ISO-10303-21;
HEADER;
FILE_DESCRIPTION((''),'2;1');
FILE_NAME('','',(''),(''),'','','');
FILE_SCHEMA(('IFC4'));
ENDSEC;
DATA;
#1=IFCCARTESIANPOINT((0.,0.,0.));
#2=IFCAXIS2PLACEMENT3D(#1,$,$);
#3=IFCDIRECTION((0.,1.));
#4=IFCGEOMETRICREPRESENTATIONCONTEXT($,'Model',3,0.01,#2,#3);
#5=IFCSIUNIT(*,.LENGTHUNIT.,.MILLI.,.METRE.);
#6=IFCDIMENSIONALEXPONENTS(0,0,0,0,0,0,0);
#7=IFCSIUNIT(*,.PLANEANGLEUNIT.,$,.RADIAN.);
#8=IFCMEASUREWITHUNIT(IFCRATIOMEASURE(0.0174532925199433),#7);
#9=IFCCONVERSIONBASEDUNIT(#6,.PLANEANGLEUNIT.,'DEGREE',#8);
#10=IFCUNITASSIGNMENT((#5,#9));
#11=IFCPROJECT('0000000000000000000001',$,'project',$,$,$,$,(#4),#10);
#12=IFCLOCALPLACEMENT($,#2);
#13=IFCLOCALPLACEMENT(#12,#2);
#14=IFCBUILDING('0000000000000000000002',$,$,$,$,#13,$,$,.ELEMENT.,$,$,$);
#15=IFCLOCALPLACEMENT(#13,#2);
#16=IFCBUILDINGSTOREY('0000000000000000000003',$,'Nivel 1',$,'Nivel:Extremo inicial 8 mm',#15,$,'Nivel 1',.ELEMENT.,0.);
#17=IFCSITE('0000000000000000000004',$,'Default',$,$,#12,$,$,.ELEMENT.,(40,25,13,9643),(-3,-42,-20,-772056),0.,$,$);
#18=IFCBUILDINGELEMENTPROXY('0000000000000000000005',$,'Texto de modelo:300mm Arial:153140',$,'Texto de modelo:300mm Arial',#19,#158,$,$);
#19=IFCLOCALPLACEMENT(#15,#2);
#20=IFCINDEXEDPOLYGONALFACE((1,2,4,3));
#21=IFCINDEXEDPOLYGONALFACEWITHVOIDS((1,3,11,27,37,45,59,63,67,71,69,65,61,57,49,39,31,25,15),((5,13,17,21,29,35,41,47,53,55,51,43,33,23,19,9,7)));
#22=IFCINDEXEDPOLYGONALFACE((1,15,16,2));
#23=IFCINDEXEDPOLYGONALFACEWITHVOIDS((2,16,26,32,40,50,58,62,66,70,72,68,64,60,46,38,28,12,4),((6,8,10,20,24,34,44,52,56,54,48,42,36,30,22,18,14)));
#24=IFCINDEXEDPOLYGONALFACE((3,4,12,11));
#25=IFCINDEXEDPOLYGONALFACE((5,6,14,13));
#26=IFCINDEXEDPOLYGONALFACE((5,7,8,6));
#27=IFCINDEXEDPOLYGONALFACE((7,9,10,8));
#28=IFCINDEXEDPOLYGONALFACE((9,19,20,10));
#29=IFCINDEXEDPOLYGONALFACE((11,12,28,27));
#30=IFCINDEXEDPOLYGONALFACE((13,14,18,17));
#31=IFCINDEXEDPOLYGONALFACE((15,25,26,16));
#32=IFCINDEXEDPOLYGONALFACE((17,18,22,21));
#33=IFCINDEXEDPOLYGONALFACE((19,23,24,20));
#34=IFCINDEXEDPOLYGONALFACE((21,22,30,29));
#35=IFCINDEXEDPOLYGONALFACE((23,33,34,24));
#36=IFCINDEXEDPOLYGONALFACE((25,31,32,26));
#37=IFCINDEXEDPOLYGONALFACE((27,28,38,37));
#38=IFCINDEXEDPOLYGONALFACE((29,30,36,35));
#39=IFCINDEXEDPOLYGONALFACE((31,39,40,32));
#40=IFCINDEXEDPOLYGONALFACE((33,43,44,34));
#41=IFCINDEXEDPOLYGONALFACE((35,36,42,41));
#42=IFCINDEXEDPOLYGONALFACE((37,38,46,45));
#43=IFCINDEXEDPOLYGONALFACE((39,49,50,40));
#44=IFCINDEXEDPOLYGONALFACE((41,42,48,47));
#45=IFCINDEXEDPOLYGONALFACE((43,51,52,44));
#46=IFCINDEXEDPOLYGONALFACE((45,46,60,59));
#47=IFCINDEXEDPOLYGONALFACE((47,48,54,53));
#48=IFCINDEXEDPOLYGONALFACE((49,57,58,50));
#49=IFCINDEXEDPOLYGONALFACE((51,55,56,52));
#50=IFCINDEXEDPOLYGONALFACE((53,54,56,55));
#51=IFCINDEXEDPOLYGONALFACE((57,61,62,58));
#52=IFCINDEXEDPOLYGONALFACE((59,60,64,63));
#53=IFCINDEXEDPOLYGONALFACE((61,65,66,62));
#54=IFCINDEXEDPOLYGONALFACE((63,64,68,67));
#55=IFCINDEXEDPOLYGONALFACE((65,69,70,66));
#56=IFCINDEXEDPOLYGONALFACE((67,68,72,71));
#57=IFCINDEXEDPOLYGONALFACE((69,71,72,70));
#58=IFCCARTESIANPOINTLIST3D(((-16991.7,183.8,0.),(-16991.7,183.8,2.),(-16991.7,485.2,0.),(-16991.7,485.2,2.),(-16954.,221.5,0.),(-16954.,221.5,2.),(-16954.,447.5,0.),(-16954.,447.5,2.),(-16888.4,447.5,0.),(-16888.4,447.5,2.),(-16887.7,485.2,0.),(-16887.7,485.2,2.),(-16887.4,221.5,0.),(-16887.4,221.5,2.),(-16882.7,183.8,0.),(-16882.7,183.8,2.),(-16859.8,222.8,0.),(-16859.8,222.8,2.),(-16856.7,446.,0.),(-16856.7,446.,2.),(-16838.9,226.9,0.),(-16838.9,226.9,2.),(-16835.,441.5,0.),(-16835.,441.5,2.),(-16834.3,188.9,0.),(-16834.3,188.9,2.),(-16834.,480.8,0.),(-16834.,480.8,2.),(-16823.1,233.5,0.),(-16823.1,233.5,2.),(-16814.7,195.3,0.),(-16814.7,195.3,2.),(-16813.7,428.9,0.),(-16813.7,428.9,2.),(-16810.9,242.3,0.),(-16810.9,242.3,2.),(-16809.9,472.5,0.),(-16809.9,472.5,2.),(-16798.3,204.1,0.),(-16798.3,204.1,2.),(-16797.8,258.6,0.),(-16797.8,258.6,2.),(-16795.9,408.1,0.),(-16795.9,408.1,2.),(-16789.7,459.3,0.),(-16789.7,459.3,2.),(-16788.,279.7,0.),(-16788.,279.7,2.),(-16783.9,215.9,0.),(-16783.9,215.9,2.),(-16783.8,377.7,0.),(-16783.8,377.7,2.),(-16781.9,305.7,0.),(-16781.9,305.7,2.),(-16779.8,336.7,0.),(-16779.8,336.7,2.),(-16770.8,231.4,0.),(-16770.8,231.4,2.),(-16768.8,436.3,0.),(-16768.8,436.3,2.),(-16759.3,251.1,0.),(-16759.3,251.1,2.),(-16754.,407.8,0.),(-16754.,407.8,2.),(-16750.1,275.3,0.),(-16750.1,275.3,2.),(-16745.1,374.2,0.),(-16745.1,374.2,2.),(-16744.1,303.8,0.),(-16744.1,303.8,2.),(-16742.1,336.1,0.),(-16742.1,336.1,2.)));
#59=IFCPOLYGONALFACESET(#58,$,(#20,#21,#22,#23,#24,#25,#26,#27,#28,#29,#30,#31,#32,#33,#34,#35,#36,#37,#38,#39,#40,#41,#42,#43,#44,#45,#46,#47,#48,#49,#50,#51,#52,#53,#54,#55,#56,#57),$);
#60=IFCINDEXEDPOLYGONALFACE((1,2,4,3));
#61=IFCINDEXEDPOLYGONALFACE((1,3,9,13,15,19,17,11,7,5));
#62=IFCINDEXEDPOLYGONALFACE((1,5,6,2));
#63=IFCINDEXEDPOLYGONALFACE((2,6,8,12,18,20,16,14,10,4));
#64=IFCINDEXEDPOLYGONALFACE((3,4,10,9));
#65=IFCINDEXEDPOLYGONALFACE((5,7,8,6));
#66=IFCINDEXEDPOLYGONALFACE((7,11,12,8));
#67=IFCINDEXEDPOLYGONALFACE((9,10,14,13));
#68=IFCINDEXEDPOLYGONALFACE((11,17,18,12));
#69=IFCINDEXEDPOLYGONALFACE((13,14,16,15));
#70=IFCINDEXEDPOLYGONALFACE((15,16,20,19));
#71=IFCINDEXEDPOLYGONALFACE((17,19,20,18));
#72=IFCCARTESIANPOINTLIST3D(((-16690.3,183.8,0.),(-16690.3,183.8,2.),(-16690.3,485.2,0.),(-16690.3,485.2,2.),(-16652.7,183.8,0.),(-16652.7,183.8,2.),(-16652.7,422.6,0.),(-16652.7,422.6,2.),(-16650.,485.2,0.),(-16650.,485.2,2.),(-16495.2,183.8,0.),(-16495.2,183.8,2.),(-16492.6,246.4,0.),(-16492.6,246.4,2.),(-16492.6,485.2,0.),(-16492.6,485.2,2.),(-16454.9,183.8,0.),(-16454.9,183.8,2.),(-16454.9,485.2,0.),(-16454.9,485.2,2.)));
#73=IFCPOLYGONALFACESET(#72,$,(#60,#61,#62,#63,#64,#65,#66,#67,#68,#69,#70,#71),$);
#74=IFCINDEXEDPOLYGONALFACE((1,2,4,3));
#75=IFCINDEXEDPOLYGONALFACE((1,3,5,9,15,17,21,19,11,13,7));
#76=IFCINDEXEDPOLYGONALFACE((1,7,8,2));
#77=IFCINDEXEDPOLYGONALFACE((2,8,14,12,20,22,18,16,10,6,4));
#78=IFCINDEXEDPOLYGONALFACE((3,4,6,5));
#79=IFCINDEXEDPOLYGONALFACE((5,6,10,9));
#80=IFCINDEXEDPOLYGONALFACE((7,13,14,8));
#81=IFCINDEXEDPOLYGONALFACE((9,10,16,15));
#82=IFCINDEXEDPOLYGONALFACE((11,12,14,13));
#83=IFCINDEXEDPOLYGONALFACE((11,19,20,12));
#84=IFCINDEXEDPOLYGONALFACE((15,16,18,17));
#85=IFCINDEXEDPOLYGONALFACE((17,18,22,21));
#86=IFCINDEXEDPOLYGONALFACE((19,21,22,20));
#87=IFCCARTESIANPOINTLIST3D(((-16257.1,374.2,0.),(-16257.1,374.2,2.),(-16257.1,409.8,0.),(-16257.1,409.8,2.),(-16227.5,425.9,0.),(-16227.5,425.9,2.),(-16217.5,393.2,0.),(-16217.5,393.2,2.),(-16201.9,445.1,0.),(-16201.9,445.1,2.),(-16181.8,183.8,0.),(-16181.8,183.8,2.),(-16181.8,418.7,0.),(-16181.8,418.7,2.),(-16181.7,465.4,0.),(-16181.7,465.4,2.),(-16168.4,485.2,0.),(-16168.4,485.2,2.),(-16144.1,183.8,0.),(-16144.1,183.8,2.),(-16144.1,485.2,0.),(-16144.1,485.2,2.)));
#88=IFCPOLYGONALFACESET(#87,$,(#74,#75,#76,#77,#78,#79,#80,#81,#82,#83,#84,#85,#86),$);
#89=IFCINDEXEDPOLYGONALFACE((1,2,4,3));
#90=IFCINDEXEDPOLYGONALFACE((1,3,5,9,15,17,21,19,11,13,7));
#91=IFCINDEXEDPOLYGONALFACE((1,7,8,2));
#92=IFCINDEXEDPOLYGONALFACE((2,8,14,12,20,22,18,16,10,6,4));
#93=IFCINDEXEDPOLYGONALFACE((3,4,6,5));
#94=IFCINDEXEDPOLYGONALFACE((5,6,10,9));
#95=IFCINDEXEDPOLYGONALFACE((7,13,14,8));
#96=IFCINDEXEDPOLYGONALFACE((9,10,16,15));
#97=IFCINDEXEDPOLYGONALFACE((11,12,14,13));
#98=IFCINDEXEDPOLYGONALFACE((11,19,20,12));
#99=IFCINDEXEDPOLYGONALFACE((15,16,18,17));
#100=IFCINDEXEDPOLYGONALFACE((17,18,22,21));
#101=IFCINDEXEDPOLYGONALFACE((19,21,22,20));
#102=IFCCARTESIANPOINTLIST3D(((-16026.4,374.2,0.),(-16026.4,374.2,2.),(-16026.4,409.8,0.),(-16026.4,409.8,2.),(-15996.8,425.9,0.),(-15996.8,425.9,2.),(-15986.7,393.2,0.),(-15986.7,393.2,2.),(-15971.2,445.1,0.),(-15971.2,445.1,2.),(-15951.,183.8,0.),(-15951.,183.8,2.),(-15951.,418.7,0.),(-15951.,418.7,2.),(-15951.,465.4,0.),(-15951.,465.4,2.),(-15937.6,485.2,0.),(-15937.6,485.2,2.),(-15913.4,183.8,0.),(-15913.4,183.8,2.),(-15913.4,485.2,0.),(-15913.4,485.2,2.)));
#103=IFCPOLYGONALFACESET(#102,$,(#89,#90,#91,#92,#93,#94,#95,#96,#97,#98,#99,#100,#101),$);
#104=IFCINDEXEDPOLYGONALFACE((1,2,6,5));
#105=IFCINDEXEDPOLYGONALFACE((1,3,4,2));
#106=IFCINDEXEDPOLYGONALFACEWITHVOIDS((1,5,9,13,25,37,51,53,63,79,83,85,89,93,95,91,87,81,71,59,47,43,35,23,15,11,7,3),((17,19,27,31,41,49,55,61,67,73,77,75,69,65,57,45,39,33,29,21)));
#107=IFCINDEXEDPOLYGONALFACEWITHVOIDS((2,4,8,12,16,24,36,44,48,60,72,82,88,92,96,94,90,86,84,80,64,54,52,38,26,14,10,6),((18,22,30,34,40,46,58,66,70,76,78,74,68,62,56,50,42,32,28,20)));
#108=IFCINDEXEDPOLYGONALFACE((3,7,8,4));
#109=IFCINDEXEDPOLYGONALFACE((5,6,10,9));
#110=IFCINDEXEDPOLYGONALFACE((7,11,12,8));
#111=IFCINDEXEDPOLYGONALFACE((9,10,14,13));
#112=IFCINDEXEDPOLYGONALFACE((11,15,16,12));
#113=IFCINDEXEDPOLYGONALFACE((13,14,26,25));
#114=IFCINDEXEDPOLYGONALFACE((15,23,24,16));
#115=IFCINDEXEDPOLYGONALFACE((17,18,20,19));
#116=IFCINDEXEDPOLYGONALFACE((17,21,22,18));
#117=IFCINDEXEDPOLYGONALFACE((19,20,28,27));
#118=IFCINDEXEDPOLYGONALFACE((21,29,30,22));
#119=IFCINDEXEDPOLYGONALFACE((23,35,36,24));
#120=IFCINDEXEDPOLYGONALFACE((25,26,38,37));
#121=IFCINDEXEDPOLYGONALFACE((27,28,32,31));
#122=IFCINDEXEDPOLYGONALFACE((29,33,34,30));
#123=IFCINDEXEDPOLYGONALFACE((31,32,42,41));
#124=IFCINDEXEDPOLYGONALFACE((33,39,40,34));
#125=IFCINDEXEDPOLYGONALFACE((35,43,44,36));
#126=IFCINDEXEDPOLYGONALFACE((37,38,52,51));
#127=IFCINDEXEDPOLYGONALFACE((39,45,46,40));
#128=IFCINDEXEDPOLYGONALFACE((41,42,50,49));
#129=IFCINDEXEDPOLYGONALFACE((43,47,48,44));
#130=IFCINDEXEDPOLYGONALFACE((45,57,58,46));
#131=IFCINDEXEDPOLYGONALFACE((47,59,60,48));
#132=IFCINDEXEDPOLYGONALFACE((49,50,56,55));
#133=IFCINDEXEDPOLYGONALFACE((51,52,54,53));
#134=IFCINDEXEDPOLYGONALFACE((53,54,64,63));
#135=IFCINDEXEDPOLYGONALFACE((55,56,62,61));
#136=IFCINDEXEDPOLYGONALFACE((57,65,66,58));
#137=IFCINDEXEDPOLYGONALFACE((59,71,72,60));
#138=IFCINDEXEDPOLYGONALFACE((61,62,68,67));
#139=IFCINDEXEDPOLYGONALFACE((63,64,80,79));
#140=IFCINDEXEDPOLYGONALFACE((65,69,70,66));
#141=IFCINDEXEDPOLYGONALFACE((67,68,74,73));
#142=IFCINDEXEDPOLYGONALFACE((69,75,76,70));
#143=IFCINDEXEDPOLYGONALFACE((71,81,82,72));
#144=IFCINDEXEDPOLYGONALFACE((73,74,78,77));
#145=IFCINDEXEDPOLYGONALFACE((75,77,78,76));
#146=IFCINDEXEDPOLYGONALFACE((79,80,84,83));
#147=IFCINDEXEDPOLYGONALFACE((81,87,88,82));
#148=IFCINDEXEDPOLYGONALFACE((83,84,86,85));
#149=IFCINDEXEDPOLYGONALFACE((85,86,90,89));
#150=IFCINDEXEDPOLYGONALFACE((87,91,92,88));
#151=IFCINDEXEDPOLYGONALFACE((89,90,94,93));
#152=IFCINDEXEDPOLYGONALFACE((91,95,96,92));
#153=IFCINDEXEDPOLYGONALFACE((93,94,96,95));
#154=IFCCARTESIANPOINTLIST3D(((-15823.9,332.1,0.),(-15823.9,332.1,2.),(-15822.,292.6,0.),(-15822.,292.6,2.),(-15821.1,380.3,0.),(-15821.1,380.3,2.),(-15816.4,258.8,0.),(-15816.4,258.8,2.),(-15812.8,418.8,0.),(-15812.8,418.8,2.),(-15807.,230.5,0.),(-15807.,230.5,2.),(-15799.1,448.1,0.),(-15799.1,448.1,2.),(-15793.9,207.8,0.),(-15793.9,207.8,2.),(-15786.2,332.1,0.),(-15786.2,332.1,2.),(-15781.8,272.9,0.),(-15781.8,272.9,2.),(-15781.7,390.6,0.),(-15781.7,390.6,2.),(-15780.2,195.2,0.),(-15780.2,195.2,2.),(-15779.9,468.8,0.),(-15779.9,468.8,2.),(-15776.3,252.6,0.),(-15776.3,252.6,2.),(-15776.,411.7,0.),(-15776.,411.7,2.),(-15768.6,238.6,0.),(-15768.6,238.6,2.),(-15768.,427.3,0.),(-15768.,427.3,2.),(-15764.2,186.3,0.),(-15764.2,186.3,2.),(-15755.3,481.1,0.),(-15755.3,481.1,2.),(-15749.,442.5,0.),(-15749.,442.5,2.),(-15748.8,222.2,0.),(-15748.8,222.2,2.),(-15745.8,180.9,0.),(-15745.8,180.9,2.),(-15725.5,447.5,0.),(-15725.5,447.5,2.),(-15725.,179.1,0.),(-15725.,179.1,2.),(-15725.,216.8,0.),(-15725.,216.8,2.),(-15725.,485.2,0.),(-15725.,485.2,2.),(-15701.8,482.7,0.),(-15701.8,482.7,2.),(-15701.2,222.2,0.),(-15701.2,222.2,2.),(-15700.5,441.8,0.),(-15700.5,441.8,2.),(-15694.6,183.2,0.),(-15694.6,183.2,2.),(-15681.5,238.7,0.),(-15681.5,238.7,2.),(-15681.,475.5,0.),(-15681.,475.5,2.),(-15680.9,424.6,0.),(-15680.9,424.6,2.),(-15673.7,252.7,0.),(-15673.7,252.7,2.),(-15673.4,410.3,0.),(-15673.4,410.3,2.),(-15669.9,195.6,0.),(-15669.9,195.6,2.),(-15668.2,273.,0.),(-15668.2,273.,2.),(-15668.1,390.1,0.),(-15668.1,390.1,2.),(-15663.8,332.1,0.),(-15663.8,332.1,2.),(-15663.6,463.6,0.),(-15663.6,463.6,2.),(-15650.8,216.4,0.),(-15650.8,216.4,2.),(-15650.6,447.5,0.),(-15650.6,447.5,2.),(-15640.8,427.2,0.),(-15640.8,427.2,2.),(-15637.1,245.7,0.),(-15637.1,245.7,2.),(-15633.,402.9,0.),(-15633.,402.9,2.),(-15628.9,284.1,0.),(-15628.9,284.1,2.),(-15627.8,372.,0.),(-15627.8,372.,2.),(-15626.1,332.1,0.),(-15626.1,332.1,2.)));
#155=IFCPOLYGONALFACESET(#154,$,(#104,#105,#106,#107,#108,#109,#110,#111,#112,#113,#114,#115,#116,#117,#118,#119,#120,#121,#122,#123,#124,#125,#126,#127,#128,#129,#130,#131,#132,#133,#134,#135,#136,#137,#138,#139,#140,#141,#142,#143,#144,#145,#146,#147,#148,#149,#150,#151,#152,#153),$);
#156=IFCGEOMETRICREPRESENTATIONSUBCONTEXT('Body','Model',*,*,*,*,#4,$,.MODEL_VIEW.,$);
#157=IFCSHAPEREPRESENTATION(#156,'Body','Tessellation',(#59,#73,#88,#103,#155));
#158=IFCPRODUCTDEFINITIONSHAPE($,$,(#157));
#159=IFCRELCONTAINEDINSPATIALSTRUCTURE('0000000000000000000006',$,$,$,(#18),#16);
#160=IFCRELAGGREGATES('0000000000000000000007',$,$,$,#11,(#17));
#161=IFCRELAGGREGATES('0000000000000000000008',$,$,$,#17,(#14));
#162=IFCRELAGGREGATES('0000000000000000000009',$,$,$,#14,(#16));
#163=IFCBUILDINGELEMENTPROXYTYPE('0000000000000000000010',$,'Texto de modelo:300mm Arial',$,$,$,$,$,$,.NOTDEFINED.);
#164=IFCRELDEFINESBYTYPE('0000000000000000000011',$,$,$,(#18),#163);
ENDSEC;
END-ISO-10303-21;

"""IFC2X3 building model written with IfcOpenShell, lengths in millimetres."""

from ifc_helpers import new_model, entity, si_unit, converted_unit, direction, frame, origin, place, context, subcontext, project, spatial, polyline, outline, extrude, type_object, element, save


model = new_model("IFC2X3")

# Units and contexts
model_context = context("Model", 3, precision=0.01, world=origin(), true_north=direction((0.0, 1.0)))
body_context = subcontext(model_context, "Body", "Model", "MODEL_VIEW")
ifc_project = project(units=[si_unit("LENGTHUNIT", "METRE", prefix="MILLI"), converted_unit("PLANEANGLEUNIT", "DEGREE", entity("IfcRatioMeasure", 0.0174532925199433), si_unit("PLANEANGLEUNIT", "RADIAN"), dimensions=[0, 0, 0, 0, 0, 0, 0])], contexts=[model_context])

# Site, building, storey
site_placement = place(None, origin())
site = spatial("IfcSite", under=ifc_project, at=site_placement, Name="Default", CompositionType="ELEMENT", RefLatitude=(40, 25, 13, 9643), RefLongitude=(-3, -42, -20, -772056), RefElevation=0.0)
building_placement = place(site_placement, origin())
building = spatial("IfcBuilding", under=site, at=building_placement, CompositionType="ELEMENT")
storey_placement = place(building_placement, origin())
storey = spatial("IfcBuildingStorey", under=building, at=storey_placement, Name="Nivel 1", ObjectType="Nivel:Extremo inicial 8 mm", LongName="Nivel 1", CompositionType="ELEMENT", Elevation=0.0)

# Building element proxy
building_element_proxy_type_1 = type_object("IfcBuildingElementProxyType", Name="Texto de modelo:300mm Arial", PredefinedType="NOTDEFINED")
proxy_1_placement = place(storey_placement, frame((-16991.7, 179.1, 0.0)))
element("IfcBuildingElementProxy", 1, at=proxy_1_placement, inside=storey, type_object=building_element_proxy_type_1, Name="Texto de modelo:300mm Arial:153140", ObjectType="Texto de modelo:300mm Arial", context=body_context, shape_type="SweptSolid", body=[
    extrude(outline(polyline([(-178.4, -141.0), (-69.4, -141.0), (-21.0, -135.8), (-1.4, -129.5), (15.0, -120.7), (29.4, -108.9), (42.6, -93.4), (54.0, -73.7), (63.2, -49.5), (69.2, -21.0), (71.2, 11.3), (68.2, 49.4), (59.3, 83.0), (44.5, 111.5), (23.7, 134.5), (3.4, 147.7), (-20.6, 156.1), (-74.4, 160.4), (-178.4, 160.4), (-178.4, -141.0)]), holes=[polyline([(-140.7, -103.3), (-140.7, 122.7), (-75.1, 122.7), (-43.3, 121.2), (-21.7, 116.7), (-0.4, 104.1), (17.4, 83.3), (29.5, 53.0), (33.5, 11.9), (31.5, -19.1), (25.3, -45.1), (15.5, -66.2), (2.4, -82.5), (-9.8, -91.3), (-25.6, -97.9), (-46.5, -101.9), (-74.1, -103.3), (-140.7, -103.3)])]), frame((178.4, 145.7, 0.0)), (0.0, 0.0, 1.0), 2.0),
    extrude(outline(polyline([(-117.7, -150.7), (-80.1, -150.7), (-80.1, 88.1), (77.4, -150.7), (117.7, -150.7), (117.7, 150.7), (80.1, 150.7), (80.1, -88.1), (-77.4, 150.7), (-117.7, 150.7), (-117.7, -150.7)])), frame((419.1, 155.4, 0.0)), (0.0, 0.0, 1.0), 2.0),
    extrude(outline(polyline([(-204.4, -52.5), (97.0, -52.5), (97.0, -28.2), (77.2, -14.9), (56.9, 5.3), (37.7, 30.9), (21.6, 60.5), (-14.0, 60.5), (5.0, 20.8), (30.4, -14.9), (-204.4, -14.9), (-204.4, -52.5)])), frame((795.1, 209.1, 0.0), z_axis=(0.0, 0.0, 1.0), x_axis=(0.0, 1.0, 0.0)), (0.0, 0.0, 1.0), 2.0),
    extrude(outline(polyline([(-204.4, -52.5), (97.0, -52.5), (97.0, -28.2), (77.2, -14.9), (56.9, 5.3), (37.7, 30.9), (21.6, 60.5), (-14.0, 60.5), (5.0, 20.8), (30.4, -14.9), (-204.4, -14.9), (-204.4, -52.5)])), frame((1025.8, 209.1, 0.0), z_axis=(0.0, 0.0, 1.0), x_axis=(0.0, 1.0, 0.0)), (0.0, 0.0, 1.0), 2.0),
    extrude(outline(polyline([(-5.6, -99.5), (33.9, -99.5), (68.0, -95.5), (96.7, -87.5), (120.0, -75.5), (133.2, -62.4), (142.9, -46.8), (149.1, -28.7), (151.9, -8.0), (149.2, 22.6), (138.0, 47.8), (118.2, 67.9), (89.5, 82.9), (51.6, 93.0), (3.8, 98.0), (-36.2, 98.2), (-67.3, 94.5), (-91.9, 87.9), (-112.6, 79.0), (-129.4, 66.8), (-142.0, 50.0), (-150.3, 29.6), (-153.8, 6.5), (-151.2, -23.9), (-140.1, -49.1), (-120.3, -69.2), (-91.7, -84.4), (-53.6, -94.5), (-5.6, -99.5)]), holes=[polyline([(-3.9, -61.9), (-62.1, -54.6), (-82.9, -47.9), (-98.1, -39.2), (-112.3, -19.5), (-116.2, 4.3), (-109.3, 28.9), (-91.2, 47.7), (-76.5, 54.5), (-56.1, 58.9), (1.9, 60.4), (60.8, 53.2), (80.8, 46.7), (94.5, 38.3), (109.9, 17.8), (114.3, -6.3), (107.7, -29.8), (90.4, -48.7), (76.0, -55.8), (55.5, -60.3), (-3.9, -61.9)])]), frame((1267.5, 152.1, 0.0), z_axis=(0.0, 0.0, 1.0), x_axis=(0.047515, -0.998871, 0.0)), (0.0, 0.0, 1.0), 2.0),
])

save(model, "model.ifc")
